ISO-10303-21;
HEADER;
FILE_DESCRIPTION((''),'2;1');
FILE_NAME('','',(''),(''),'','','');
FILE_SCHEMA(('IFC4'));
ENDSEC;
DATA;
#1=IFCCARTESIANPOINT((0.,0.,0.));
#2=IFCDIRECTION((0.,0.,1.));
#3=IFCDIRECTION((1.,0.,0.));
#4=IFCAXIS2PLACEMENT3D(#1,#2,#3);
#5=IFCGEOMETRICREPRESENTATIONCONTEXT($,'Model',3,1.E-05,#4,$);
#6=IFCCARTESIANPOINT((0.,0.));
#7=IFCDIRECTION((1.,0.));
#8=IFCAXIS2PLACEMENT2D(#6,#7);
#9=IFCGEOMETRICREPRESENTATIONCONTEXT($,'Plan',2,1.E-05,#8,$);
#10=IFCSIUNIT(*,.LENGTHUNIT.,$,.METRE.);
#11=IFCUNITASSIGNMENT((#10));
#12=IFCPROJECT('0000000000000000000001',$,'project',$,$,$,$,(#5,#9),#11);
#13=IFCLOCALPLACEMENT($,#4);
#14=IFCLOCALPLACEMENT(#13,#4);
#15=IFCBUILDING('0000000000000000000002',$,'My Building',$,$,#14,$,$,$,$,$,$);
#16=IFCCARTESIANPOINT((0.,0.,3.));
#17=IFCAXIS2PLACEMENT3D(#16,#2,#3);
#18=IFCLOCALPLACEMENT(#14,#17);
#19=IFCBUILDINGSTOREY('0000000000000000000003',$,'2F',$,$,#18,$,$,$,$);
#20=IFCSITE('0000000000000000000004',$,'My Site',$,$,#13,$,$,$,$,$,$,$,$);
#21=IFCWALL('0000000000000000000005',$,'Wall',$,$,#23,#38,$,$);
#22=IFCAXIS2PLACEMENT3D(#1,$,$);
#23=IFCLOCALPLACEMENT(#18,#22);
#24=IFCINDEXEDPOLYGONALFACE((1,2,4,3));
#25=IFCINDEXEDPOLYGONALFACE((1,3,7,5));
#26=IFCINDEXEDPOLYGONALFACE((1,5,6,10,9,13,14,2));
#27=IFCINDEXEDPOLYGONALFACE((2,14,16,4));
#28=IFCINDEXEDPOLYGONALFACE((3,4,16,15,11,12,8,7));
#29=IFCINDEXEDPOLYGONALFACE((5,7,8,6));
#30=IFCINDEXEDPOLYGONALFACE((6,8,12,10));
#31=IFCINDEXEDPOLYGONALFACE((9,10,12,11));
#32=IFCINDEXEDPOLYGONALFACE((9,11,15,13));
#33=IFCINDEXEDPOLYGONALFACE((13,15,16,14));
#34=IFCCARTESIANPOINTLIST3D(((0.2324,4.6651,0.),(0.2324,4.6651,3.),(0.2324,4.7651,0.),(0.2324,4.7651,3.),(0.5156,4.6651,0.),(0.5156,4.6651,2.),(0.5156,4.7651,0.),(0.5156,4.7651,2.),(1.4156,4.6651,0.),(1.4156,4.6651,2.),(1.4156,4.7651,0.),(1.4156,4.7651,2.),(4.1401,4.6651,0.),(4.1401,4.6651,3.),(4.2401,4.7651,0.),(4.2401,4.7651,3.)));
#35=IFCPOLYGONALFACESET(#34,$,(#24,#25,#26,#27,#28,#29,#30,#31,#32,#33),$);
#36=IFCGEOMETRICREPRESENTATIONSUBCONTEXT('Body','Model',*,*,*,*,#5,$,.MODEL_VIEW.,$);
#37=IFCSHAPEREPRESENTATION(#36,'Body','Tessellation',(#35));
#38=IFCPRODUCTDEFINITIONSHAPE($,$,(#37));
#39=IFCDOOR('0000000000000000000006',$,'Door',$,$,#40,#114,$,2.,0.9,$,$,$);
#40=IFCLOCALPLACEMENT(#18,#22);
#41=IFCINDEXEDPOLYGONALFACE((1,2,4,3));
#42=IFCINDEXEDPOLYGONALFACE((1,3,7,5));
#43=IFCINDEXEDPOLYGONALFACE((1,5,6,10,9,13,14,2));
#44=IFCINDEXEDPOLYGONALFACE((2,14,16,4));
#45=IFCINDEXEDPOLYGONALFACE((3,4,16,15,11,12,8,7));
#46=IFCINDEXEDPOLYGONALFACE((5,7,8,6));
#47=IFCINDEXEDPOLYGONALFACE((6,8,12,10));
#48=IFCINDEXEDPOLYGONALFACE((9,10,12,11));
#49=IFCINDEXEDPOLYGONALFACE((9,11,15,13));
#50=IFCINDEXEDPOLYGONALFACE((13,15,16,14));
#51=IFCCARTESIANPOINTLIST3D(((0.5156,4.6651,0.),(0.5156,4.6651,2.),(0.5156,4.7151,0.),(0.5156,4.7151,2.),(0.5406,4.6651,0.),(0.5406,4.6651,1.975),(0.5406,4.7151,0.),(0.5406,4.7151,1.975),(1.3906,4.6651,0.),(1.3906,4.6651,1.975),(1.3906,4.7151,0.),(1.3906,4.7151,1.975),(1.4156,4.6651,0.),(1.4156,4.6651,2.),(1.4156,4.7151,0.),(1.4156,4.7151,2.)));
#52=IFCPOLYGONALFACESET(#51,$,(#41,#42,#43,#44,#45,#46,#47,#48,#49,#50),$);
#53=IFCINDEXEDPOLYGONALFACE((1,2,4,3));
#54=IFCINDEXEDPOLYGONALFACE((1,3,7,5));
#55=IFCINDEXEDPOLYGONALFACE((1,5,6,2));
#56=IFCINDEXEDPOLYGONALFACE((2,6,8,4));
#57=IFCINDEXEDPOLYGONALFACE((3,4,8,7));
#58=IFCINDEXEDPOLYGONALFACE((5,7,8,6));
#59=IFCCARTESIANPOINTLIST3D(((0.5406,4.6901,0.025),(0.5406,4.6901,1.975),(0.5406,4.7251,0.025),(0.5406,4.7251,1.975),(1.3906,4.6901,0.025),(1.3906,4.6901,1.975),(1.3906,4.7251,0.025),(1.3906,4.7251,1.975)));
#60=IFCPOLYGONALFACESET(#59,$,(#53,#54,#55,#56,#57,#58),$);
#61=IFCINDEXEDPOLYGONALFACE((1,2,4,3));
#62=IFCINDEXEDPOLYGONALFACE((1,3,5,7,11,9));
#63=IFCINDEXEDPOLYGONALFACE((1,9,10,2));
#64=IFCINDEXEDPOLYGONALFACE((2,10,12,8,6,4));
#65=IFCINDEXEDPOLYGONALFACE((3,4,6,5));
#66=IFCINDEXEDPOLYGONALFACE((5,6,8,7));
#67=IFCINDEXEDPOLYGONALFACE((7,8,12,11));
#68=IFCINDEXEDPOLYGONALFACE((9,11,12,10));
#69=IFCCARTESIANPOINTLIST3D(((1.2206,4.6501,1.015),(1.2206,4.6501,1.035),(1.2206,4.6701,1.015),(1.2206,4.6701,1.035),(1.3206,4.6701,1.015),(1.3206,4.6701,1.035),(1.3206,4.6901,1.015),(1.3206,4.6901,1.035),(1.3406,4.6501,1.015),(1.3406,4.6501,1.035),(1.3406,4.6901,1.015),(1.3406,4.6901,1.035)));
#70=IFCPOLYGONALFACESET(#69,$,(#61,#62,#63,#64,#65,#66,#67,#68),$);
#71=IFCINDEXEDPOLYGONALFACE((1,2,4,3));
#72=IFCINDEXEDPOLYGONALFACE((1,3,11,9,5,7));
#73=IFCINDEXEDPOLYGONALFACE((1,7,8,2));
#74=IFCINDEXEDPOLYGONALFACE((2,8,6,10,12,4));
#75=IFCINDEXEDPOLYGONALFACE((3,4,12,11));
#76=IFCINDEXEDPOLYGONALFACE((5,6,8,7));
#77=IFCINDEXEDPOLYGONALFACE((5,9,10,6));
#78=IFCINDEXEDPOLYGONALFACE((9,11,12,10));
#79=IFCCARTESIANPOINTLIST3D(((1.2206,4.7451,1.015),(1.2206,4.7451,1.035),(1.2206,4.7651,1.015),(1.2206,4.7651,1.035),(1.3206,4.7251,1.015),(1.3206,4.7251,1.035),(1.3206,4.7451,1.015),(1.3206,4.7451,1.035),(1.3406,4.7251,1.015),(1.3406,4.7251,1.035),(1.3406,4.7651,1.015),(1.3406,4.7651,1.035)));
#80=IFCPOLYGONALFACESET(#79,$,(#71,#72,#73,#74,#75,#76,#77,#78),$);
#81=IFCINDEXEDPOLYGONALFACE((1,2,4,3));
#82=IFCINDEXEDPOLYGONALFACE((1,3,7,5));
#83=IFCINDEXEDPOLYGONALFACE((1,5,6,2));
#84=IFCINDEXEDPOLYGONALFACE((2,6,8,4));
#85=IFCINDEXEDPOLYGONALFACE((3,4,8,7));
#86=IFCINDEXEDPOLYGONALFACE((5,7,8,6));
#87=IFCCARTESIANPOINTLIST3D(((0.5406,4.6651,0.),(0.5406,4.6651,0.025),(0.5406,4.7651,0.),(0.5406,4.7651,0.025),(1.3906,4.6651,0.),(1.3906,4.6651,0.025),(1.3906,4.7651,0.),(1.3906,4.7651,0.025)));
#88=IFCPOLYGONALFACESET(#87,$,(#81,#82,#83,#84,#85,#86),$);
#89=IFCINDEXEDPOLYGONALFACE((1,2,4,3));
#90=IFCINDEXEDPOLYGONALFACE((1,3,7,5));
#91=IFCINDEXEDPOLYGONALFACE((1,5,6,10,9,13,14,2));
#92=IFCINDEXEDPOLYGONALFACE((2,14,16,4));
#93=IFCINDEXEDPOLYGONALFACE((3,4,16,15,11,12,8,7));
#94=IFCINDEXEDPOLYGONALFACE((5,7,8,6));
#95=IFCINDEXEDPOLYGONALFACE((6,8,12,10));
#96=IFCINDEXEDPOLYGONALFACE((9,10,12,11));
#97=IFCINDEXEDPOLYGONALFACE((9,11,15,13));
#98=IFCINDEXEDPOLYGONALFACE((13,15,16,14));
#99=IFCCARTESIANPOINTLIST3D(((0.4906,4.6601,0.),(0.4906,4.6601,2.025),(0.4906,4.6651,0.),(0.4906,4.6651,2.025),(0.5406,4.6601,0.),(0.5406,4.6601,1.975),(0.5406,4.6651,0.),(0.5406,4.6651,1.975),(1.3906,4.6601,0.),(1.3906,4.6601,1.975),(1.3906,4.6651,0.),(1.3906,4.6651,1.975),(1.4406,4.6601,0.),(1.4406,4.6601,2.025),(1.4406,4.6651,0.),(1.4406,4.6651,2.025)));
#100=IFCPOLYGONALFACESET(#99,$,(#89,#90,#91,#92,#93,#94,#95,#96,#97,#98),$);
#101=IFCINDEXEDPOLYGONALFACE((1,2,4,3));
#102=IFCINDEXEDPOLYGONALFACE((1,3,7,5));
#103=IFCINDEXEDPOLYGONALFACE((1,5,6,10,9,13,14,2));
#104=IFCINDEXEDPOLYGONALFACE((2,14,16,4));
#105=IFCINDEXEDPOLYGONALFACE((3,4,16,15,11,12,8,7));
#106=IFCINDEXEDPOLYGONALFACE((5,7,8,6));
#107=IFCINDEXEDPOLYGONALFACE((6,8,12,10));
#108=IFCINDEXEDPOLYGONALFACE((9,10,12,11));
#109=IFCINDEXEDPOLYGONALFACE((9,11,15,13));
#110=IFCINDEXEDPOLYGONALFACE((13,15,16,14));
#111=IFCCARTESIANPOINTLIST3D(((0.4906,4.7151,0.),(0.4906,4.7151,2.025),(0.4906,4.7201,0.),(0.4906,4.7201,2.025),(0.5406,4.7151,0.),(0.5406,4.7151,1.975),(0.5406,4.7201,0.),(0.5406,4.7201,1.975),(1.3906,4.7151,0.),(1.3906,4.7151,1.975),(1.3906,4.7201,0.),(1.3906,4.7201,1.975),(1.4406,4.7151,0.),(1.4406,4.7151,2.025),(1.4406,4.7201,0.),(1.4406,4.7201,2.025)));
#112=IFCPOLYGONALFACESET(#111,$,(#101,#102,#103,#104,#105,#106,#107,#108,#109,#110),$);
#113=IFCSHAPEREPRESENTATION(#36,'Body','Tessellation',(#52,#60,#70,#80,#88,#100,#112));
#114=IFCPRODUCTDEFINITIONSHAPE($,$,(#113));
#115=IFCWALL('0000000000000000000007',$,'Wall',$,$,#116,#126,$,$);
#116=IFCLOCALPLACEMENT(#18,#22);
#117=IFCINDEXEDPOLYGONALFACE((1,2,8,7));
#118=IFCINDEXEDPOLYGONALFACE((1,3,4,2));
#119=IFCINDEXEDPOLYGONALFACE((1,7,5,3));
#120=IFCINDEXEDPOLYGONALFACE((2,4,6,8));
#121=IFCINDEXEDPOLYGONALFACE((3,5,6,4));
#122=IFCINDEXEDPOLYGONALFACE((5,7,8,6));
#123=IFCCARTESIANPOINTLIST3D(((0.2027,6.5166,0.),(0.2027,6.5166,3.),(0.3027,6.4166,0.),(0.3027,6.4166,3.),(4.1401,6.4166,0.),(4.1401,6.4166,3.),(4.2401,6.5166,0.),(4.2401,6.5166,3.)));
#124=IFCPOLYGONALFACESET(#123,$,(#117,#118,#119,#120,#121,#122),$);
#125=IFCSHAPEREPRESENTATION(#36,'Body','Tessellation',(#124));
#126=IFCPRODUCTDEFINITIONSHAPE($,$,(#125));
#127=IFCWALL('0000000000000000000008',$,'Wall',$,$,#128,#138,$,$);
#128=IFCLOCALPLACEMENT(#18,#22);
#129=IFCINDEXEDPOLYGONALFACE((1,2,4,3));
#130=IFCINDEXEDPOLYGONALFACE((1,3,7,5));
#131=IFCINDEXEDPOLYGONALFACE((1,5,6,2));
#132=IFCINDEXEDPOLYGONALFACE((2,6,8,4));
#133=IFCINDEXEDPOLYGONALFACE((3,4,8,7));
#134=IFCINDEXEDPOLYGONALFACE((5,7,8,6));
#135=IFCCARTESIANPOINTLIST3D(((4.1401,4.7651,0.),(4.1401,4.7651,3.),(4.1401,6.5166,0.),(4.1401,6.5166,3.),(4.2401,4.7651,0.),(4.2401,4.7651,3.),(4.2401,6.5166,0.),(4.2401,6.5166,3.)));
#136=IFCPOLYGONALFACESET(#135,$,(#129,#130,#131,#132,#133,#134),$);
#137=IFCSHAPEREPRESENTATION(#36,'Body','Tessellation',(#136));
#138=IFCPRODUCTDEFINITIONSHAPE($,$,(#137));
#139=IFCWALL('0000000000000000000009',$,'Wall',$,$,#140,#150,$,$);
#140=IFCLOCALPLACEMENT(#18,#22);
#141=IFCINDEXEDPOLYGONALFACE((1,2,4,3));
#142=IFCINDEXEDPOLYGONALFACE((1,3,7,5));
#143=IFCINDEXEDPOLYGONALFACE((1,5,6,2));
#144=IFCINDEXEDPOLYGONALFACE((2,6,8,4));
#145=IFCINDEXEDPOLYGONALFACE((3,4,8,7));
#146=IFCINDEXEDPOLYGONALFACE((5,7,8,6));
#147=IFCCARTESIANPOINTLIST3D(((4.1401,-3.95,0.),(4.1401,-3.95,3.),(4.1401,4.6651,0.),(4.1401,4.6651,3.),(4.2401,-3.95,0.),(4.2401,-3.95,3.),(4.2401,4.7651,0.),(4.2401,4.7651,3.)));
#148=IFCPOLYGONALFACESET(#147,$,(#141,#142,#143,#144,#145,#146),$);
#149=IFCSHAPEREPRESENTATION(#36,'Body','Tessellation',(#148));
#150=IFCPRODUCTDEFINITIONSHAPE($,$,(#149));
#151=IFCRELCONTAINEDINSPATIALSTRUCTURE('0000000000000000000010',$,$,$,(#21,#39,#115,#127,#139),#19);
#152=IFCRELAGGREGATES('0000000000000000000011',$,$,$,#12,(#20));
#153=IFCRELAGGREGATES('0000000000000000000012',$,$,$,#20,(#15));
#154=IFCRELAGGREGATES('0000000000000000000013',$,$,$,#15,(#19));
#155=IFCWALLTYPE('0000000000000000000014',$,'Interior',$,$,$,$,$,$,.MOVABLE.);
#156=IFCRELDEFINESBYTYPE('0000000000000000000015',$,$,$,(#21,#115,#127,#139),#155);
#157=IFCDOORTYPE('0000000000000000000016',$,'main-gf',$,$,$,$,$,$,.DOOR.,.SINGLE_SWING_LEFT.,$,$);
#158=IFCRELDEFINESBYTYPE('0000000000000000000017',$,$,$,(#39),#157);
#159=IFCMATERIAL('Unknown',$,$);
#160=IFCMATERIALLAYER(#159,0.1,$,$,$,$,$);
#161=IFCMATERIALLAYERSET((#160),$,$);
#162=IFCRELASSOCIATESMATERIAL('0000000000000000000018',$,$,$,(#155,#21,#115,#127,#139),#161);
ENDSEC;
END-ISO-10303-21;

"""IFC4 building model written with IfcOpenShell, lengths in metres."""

from ifc_helpers import new_model, entity, si_unit, frame, origin_with_axes, origin_2d_with_axis, place, context, subcontext, project, spatial, line, indexed_curve, outline, extrude, shape, source, transform, mapped, material, layer, layer_set, layer_usage, type_object, type_shapes, element, fill, save


model = new_model("IFC4")

# Units and contexts
model_context = context("Model", 3, precision=1e-05, world=origin_with_axes())
plan_context = context("Plan", 2, precision=1e-05, world=origin_2d_with_axis())
body_context_1 = subcontext(model_context, "Body", "Model", "MODEL_VIEW")
body_context_2 = subcontext(plan_context, "Body", "Plan", "PLAN_VIEW")
ifc_project = project(units=[si_unit("LENGTHUNIT", "METRE")], contexts=[model_context, plan_context])

# Site, building, storey
site_placement = place(None, origin_with_axes())
site = spatial("IfcSite", under=ifc_project, at=site_placement, Name="My Site")
building_placement = place(site_placement, origin_with_axes())
building = spatial("IfcBuilding", under=site, at=building_placement, Name="My Building")
storey_placement = place(building_placement, frame((0.0, 0.0, 3.0), z_axis=(0.0, 0.0, 1.0), x_axis=(1.0, 0.0, 0.0)))
storey = spatial("IfcBuildingStorey", under=building, at=storey_placement, Name="2F")

# Shared definitions
ifc_material = material(Name="Unknown")

# Shared definitions
ifc_layer_1 = layer(ifc_material, 0.1)
ifc_layer_set_1 = layer_set([ifc_layer_1])
wall_type = type_object("IfcWallType", Name="Interior", PredefinedType="MOVABLE", material=ifc_layer_set_1)

# Wall, opening, door
shared_shape_1 = source(origin_with_axes(), body_context_1, "Body", "SweptSolid", [
    extrude(outline(indexed_curve([(0.0, 0.0), (0.9, 0.0), (0.9, 2.0), (0.0, 2.0)], segments=[line(1, 2, 3, 4, 1)])), frame((0.0, -0.6, 0.0), z_axis=(0.0, -1.0, 0.0), x_axis=(1.0, 0.0, 0.0)), (0.0, 0.0, -1.0), 1.2),
])
door_type = type_object("IfcDoorType", Name="main-gf", OperationType="SINGLE_SWING_LEFT", PredefinedType="DOOR")
shared_shape_2 = source(origin_with_axes(), body_context_1, "Body", "SweptSolid", [
    extrude(outline(indexed_curve([(0.0, 0.0), (0.0, 2.0), (0.9, 2.0), (0.9, 0.0), (0.875, 0.0), (0.875, 1.975), (0.025, 1.975), (0.025, 0.0)], segments=[line(1, 2, 3, 4, 5, 6, 7, 8, 1)])), frame((0.0, 0.0, 0.0), z_axis=(0.0, -1.0, 0.0), x_axis=(1.0, 0.0, 0.0)), (0.0, 0.0, -1.0), 0.05),
    extrude(outline(indexed_curve([(0.0, 0.0), (0.85, 0.0), (0.85, 0.035), (0.0, 0.035)], segments=[line(1, 2, 3, 4, 1)])), frame((0.025, 0.025, 0.025), z_axis=(0.0, 0.0, 1.0), x_axis=(1.0, 0.0, 0.0)), (0.0, 0.0, 1.0), 1.95),
    extrude(outline(indexed_curve([(0.0, 0.0), (0.0, -0.04), (-0.12, -0.04), (-0.12, -0.02), (-0.02, -0.02), (-0.02, 0.0)], segments=[line(1, 2, 3, 4, 5, 6, 1)])), frame((0.825, 0.025, 1.015), z_axis=(0.0, 0.0, 1.0), x_axis=(1.0, 0.0, 0.0)), (0.0, 0.0, 1.0), 0.02),
    extrude(outline(indexed_curve([(0.0, 0.0), (0.0, 0.04), (-0.12, 0.04), (-0.12, 0.02), (-0.02, 0.02), (-0.02, 0.0)], segments=[line(1, 2, 3, 4, 5, 6, 1)])), frame((0.825, 0.06, 1.015), z_axis=(0.0, 0.0, 1.0), x_axis=(1.0, 0.0, 0.0)), (0.0, 0.0, 1.0), 0.02),
    extrude(outline(indexed_curve([(0.0, 0.0), (0.85, 0.0), (0.85, 0.1), (0.0, 0.1)], segments=[line(1, 2, 3, 4, 1)])), frame((0.025, 0.0, 0.0), z_axis=(0.0, 0.0, 1.0), x_axis=(1.0, 0.0, 0.0)), (0.0, 0.0, 1.0), 0.025),
    extrude(outline(indexed_curve([(0.0, 0.0), (0.0, 2.025), (0.95, 2.025), (0.95, 0.0), (0.9, 0.0), (0.9, 1.975), (0.05, 1.975), (0.05, 0.0)], segments=[line(1, 2, 3, 4, 5, 6, 7, 8, 1)])), frame((-0.025, -0.005, 0.0), z_axis=(0.0, -1.0, 0.0), x_axis=(1.0, 0.0, 0.0)), (0.0, 0.0, -1.0), 0.005),
    extrude(outline(indexed_curve([(0.0, 0.0), (0.0, 2.025), (0.95, 2.025), (0.95, 0.0), (0.9, 0.0), (0.9, 1.975), (0.05, 1.975), (0.05, 0.0)], segments=[line(1, 2, 3, 4, 5, 6, 7, 8, 1)])), frame((-0.025, 0.05, 0.0), z_axis=(0.0, -1.0, 0.0), x_axis=(1.0, 0.0, 0.0)), (0.0, 0.0, -1.0), 0.005),
])
shared_shape_3 = source(origin_with_axes(), body_context_2, "Body", "Curve2D", [
    entity("IfcIndexedPolyCurve", entity("IfcCartesianPointList2D", [[0.0, 0.0], [0.025, 0.0], [0.025, 0.05], [0.0, 0.05]]), [entity("IfcLineIndex", [1, 2, 3, 4, 1])]),
    entity("IfcIndexedPolyCurve", entity("IfcCartesianPointList2D", [[0.9, 0.0], [0.875, 0.0], [0.875, 0.05], [0.9, 0.05]]), [entity("IfcLineIndex", [1, 2, 3, 4, 1])]),
    entity("IfcIndexedPolyCurve", entity("IfcCartesianPointList2D", [[0.025, 0.05], [0.025, -0.8], [0.06, -0.8]])),
    entity("IfcTrimmedCurve", entity("IfcEllipse", entity("IfcAxis2Placement2D", entity("IfcCartesianPoint", [0.06, 0.05]), entity("IfcDirection", [1.0, 0.0])), 0.815, 0.85), [entity("IfcCartesianPoint", [0.06, -0.8])], [entity("IfcCartesianPoint", [0.06, 0.9])], True, "CARTESIAN"),
    entity("IfcIndexedPolyCurve", entity("IfcCartesianPointList2D", [[0.025, 0.05], [0.06, 0.05], [0.06, 0.9], [0.025, 0.9]]), [entity("IfcLineIndex", [1, 2, 3, 4, 1])]),
])
type_shapes(door_type, [shared_shape_2, shared_shape_3])
ifc_layer_usage_1 = layer_usage(ifc_layer_set_1, "AXIS2", "POSITIVE", 0.0)
wall_1_placement = place(storey_placement, frame((4.1401, 4.7651, 0.0), z_axis=(0.0, 0.0, 1.0), x_axis=(-1.0, 0.0, 0.0)))
wall_1 = element("IfcWall", 1, at=wall_1_placement, inside=storey, type_object=wall_type, material=ifc_layer_usage_1, Name="Wall", context=body_context_1, shape_type="SweptSolid", body=[
    extrude(outline(indexed_curve([(-0.1, 0.0), (0.0, 0.1), (3.9077, 0.1), (3.9077, 0.0)], segments=[line(1, 2, 3, 4, 1)])), origin_with_axes(), (0.0, 0.0, 1.0), 3.0),
])
opening_1_placement = place(wall_1_placement, frame((3.6245, 0.1, 0.0), z_axis=(0.0, 0.0, 1.0), x_axis=(-1.0, 0.0, 0.0)))
opening_1 = element("IfcOpeningElement", 2, at=opening_1_placement, cuts=wall_1, PredefinedType="OPENING", context=body_context_1, shape_type="MappedRepresentation", body=[
    mapped(shared_shape_1, transform((0.0, 0.0, 0.0), x_axis=(1.0, 0.0, 0.0), y_axis=(0.0, 1.0, 0.0), z_axis=(0.0, 0.0, 1.0), scale=1.0)),
])
door_1_placement = place(opening_1_placement, frame((0.0, 0.0, 0.0), z_axis=(0.0, 0.0, 1.0), x_axis=(1.0, 0.0, 0.0)))
door_1 = element("IfcDoor", 3, at=door_1_placement, inside=storey, type_object=door_type, Name="Door", OverallHeight=2.0, OverallWidth=0.9, shapes=[
    shape(body_context_1, "Body", "MappedRepresentation", [mapped(shared_shape_2, transform((0.0, 0.0, 0.0), x_axis=(1.0, 0.0, 0.0), y_axis=(0.0, 1.0, 0.0), z_axis=(0.0, 0.0, 1.0), scale=1.0))]),
    shape(body_context_2, "Body", "MappedRepresentation", [mapped(shared_shape_3, transform((0.0, 0.0, 0.0), x_axis=(1.0, 0.0, 0.0), y_axis=(0.0, 1.0, 0.0), z_axis=(0.0, 0.0, 1.0), scale=1.0))]),
])
fill(opening_1, door_1)

# Walls
ifc_layer_usage_2 = layer_usage(ifc_layer_set_1, "AXIS2", "POSITIVE", 0.0)
wall_2_placement = place(storey_placement, frame((4.2401, 6.5166, 0.0), z_axis=(0.0, 0.0, 1.0), x_axis=(-1.0, 0.0, 0.0)))
element("IfcWall", 4, at=wall_2_placement, inside=storey, type_object=wall_type, material=ifc_layer_usage_2, Name="Wall", context=body_context_1, shape_type="SweptSolid", body=[
    extrude(outline(indexed_curve([(0.0, 0.0), (0.1, 0.1), (3.9373, 0.1), (4.0373, 0.0)], segments=[line(1, 2, 3, 4, 1)])), origin_with_axes(), (0.0, 0.0, 1.0), 3.0),
])
ifc_layer_usage_3 = layer_usage(ifc_layer_set_1, "AXIS2", "POSITIVE", 0.0)
wall_3_placement = place(storey_placement, frame((4.2401, 4.7651, 0.0), z_axis=(0.0, 0.0, 1.0), x_axis=(0.0, 1.0, 0.0)))
element("IfcWall", 5, at=wall_3_placement, inside=storey, type_object=wall_type, material=ifc_layer_usage_3, Name="Wall", context=body_context_1, shape_type="SweptSolid", body=[
    extrude(outline(indexed_curve([(0.0, 0.0), (0.0, 0.1), (1.7515, 0.1), (1.7515, 0.0)], segments=[line(1, 2, 3, 4, 1)])), origin_with_axes(), (0.0, 0.0, 1.0), 3.0),
])
ifc_layer_usage_4 = layer_usage(ifc_layer_set_1, "AXIS2", "POSITIVE", 0.0)
wall_4_placement = place(storey_placement, frame((4.1401, 4.7651, 0.0), z_axis=(0.0, 0.0, 1.0), x_axis=(0.0, -1.0, 0.0)))
element("IfcWall", 6, at=wall_4_placement, inside=storey, type_object=wall_type, material=ifc_layer_usage_4, Name="Wall", context=body_context_1, shape_type="SweptSolid", body=[
    extrude(outline(indexed_curve([(0.1, 0.0), (0.0, 0.1), (8.7151, 0.1), (8.7151, 0.0)], segments=[line(1, 2, 3, 4, 1)])), origin_with_axes(), (0.0, 0.0, 1.0), 3.0),
])

save(model, "model.ifc")
